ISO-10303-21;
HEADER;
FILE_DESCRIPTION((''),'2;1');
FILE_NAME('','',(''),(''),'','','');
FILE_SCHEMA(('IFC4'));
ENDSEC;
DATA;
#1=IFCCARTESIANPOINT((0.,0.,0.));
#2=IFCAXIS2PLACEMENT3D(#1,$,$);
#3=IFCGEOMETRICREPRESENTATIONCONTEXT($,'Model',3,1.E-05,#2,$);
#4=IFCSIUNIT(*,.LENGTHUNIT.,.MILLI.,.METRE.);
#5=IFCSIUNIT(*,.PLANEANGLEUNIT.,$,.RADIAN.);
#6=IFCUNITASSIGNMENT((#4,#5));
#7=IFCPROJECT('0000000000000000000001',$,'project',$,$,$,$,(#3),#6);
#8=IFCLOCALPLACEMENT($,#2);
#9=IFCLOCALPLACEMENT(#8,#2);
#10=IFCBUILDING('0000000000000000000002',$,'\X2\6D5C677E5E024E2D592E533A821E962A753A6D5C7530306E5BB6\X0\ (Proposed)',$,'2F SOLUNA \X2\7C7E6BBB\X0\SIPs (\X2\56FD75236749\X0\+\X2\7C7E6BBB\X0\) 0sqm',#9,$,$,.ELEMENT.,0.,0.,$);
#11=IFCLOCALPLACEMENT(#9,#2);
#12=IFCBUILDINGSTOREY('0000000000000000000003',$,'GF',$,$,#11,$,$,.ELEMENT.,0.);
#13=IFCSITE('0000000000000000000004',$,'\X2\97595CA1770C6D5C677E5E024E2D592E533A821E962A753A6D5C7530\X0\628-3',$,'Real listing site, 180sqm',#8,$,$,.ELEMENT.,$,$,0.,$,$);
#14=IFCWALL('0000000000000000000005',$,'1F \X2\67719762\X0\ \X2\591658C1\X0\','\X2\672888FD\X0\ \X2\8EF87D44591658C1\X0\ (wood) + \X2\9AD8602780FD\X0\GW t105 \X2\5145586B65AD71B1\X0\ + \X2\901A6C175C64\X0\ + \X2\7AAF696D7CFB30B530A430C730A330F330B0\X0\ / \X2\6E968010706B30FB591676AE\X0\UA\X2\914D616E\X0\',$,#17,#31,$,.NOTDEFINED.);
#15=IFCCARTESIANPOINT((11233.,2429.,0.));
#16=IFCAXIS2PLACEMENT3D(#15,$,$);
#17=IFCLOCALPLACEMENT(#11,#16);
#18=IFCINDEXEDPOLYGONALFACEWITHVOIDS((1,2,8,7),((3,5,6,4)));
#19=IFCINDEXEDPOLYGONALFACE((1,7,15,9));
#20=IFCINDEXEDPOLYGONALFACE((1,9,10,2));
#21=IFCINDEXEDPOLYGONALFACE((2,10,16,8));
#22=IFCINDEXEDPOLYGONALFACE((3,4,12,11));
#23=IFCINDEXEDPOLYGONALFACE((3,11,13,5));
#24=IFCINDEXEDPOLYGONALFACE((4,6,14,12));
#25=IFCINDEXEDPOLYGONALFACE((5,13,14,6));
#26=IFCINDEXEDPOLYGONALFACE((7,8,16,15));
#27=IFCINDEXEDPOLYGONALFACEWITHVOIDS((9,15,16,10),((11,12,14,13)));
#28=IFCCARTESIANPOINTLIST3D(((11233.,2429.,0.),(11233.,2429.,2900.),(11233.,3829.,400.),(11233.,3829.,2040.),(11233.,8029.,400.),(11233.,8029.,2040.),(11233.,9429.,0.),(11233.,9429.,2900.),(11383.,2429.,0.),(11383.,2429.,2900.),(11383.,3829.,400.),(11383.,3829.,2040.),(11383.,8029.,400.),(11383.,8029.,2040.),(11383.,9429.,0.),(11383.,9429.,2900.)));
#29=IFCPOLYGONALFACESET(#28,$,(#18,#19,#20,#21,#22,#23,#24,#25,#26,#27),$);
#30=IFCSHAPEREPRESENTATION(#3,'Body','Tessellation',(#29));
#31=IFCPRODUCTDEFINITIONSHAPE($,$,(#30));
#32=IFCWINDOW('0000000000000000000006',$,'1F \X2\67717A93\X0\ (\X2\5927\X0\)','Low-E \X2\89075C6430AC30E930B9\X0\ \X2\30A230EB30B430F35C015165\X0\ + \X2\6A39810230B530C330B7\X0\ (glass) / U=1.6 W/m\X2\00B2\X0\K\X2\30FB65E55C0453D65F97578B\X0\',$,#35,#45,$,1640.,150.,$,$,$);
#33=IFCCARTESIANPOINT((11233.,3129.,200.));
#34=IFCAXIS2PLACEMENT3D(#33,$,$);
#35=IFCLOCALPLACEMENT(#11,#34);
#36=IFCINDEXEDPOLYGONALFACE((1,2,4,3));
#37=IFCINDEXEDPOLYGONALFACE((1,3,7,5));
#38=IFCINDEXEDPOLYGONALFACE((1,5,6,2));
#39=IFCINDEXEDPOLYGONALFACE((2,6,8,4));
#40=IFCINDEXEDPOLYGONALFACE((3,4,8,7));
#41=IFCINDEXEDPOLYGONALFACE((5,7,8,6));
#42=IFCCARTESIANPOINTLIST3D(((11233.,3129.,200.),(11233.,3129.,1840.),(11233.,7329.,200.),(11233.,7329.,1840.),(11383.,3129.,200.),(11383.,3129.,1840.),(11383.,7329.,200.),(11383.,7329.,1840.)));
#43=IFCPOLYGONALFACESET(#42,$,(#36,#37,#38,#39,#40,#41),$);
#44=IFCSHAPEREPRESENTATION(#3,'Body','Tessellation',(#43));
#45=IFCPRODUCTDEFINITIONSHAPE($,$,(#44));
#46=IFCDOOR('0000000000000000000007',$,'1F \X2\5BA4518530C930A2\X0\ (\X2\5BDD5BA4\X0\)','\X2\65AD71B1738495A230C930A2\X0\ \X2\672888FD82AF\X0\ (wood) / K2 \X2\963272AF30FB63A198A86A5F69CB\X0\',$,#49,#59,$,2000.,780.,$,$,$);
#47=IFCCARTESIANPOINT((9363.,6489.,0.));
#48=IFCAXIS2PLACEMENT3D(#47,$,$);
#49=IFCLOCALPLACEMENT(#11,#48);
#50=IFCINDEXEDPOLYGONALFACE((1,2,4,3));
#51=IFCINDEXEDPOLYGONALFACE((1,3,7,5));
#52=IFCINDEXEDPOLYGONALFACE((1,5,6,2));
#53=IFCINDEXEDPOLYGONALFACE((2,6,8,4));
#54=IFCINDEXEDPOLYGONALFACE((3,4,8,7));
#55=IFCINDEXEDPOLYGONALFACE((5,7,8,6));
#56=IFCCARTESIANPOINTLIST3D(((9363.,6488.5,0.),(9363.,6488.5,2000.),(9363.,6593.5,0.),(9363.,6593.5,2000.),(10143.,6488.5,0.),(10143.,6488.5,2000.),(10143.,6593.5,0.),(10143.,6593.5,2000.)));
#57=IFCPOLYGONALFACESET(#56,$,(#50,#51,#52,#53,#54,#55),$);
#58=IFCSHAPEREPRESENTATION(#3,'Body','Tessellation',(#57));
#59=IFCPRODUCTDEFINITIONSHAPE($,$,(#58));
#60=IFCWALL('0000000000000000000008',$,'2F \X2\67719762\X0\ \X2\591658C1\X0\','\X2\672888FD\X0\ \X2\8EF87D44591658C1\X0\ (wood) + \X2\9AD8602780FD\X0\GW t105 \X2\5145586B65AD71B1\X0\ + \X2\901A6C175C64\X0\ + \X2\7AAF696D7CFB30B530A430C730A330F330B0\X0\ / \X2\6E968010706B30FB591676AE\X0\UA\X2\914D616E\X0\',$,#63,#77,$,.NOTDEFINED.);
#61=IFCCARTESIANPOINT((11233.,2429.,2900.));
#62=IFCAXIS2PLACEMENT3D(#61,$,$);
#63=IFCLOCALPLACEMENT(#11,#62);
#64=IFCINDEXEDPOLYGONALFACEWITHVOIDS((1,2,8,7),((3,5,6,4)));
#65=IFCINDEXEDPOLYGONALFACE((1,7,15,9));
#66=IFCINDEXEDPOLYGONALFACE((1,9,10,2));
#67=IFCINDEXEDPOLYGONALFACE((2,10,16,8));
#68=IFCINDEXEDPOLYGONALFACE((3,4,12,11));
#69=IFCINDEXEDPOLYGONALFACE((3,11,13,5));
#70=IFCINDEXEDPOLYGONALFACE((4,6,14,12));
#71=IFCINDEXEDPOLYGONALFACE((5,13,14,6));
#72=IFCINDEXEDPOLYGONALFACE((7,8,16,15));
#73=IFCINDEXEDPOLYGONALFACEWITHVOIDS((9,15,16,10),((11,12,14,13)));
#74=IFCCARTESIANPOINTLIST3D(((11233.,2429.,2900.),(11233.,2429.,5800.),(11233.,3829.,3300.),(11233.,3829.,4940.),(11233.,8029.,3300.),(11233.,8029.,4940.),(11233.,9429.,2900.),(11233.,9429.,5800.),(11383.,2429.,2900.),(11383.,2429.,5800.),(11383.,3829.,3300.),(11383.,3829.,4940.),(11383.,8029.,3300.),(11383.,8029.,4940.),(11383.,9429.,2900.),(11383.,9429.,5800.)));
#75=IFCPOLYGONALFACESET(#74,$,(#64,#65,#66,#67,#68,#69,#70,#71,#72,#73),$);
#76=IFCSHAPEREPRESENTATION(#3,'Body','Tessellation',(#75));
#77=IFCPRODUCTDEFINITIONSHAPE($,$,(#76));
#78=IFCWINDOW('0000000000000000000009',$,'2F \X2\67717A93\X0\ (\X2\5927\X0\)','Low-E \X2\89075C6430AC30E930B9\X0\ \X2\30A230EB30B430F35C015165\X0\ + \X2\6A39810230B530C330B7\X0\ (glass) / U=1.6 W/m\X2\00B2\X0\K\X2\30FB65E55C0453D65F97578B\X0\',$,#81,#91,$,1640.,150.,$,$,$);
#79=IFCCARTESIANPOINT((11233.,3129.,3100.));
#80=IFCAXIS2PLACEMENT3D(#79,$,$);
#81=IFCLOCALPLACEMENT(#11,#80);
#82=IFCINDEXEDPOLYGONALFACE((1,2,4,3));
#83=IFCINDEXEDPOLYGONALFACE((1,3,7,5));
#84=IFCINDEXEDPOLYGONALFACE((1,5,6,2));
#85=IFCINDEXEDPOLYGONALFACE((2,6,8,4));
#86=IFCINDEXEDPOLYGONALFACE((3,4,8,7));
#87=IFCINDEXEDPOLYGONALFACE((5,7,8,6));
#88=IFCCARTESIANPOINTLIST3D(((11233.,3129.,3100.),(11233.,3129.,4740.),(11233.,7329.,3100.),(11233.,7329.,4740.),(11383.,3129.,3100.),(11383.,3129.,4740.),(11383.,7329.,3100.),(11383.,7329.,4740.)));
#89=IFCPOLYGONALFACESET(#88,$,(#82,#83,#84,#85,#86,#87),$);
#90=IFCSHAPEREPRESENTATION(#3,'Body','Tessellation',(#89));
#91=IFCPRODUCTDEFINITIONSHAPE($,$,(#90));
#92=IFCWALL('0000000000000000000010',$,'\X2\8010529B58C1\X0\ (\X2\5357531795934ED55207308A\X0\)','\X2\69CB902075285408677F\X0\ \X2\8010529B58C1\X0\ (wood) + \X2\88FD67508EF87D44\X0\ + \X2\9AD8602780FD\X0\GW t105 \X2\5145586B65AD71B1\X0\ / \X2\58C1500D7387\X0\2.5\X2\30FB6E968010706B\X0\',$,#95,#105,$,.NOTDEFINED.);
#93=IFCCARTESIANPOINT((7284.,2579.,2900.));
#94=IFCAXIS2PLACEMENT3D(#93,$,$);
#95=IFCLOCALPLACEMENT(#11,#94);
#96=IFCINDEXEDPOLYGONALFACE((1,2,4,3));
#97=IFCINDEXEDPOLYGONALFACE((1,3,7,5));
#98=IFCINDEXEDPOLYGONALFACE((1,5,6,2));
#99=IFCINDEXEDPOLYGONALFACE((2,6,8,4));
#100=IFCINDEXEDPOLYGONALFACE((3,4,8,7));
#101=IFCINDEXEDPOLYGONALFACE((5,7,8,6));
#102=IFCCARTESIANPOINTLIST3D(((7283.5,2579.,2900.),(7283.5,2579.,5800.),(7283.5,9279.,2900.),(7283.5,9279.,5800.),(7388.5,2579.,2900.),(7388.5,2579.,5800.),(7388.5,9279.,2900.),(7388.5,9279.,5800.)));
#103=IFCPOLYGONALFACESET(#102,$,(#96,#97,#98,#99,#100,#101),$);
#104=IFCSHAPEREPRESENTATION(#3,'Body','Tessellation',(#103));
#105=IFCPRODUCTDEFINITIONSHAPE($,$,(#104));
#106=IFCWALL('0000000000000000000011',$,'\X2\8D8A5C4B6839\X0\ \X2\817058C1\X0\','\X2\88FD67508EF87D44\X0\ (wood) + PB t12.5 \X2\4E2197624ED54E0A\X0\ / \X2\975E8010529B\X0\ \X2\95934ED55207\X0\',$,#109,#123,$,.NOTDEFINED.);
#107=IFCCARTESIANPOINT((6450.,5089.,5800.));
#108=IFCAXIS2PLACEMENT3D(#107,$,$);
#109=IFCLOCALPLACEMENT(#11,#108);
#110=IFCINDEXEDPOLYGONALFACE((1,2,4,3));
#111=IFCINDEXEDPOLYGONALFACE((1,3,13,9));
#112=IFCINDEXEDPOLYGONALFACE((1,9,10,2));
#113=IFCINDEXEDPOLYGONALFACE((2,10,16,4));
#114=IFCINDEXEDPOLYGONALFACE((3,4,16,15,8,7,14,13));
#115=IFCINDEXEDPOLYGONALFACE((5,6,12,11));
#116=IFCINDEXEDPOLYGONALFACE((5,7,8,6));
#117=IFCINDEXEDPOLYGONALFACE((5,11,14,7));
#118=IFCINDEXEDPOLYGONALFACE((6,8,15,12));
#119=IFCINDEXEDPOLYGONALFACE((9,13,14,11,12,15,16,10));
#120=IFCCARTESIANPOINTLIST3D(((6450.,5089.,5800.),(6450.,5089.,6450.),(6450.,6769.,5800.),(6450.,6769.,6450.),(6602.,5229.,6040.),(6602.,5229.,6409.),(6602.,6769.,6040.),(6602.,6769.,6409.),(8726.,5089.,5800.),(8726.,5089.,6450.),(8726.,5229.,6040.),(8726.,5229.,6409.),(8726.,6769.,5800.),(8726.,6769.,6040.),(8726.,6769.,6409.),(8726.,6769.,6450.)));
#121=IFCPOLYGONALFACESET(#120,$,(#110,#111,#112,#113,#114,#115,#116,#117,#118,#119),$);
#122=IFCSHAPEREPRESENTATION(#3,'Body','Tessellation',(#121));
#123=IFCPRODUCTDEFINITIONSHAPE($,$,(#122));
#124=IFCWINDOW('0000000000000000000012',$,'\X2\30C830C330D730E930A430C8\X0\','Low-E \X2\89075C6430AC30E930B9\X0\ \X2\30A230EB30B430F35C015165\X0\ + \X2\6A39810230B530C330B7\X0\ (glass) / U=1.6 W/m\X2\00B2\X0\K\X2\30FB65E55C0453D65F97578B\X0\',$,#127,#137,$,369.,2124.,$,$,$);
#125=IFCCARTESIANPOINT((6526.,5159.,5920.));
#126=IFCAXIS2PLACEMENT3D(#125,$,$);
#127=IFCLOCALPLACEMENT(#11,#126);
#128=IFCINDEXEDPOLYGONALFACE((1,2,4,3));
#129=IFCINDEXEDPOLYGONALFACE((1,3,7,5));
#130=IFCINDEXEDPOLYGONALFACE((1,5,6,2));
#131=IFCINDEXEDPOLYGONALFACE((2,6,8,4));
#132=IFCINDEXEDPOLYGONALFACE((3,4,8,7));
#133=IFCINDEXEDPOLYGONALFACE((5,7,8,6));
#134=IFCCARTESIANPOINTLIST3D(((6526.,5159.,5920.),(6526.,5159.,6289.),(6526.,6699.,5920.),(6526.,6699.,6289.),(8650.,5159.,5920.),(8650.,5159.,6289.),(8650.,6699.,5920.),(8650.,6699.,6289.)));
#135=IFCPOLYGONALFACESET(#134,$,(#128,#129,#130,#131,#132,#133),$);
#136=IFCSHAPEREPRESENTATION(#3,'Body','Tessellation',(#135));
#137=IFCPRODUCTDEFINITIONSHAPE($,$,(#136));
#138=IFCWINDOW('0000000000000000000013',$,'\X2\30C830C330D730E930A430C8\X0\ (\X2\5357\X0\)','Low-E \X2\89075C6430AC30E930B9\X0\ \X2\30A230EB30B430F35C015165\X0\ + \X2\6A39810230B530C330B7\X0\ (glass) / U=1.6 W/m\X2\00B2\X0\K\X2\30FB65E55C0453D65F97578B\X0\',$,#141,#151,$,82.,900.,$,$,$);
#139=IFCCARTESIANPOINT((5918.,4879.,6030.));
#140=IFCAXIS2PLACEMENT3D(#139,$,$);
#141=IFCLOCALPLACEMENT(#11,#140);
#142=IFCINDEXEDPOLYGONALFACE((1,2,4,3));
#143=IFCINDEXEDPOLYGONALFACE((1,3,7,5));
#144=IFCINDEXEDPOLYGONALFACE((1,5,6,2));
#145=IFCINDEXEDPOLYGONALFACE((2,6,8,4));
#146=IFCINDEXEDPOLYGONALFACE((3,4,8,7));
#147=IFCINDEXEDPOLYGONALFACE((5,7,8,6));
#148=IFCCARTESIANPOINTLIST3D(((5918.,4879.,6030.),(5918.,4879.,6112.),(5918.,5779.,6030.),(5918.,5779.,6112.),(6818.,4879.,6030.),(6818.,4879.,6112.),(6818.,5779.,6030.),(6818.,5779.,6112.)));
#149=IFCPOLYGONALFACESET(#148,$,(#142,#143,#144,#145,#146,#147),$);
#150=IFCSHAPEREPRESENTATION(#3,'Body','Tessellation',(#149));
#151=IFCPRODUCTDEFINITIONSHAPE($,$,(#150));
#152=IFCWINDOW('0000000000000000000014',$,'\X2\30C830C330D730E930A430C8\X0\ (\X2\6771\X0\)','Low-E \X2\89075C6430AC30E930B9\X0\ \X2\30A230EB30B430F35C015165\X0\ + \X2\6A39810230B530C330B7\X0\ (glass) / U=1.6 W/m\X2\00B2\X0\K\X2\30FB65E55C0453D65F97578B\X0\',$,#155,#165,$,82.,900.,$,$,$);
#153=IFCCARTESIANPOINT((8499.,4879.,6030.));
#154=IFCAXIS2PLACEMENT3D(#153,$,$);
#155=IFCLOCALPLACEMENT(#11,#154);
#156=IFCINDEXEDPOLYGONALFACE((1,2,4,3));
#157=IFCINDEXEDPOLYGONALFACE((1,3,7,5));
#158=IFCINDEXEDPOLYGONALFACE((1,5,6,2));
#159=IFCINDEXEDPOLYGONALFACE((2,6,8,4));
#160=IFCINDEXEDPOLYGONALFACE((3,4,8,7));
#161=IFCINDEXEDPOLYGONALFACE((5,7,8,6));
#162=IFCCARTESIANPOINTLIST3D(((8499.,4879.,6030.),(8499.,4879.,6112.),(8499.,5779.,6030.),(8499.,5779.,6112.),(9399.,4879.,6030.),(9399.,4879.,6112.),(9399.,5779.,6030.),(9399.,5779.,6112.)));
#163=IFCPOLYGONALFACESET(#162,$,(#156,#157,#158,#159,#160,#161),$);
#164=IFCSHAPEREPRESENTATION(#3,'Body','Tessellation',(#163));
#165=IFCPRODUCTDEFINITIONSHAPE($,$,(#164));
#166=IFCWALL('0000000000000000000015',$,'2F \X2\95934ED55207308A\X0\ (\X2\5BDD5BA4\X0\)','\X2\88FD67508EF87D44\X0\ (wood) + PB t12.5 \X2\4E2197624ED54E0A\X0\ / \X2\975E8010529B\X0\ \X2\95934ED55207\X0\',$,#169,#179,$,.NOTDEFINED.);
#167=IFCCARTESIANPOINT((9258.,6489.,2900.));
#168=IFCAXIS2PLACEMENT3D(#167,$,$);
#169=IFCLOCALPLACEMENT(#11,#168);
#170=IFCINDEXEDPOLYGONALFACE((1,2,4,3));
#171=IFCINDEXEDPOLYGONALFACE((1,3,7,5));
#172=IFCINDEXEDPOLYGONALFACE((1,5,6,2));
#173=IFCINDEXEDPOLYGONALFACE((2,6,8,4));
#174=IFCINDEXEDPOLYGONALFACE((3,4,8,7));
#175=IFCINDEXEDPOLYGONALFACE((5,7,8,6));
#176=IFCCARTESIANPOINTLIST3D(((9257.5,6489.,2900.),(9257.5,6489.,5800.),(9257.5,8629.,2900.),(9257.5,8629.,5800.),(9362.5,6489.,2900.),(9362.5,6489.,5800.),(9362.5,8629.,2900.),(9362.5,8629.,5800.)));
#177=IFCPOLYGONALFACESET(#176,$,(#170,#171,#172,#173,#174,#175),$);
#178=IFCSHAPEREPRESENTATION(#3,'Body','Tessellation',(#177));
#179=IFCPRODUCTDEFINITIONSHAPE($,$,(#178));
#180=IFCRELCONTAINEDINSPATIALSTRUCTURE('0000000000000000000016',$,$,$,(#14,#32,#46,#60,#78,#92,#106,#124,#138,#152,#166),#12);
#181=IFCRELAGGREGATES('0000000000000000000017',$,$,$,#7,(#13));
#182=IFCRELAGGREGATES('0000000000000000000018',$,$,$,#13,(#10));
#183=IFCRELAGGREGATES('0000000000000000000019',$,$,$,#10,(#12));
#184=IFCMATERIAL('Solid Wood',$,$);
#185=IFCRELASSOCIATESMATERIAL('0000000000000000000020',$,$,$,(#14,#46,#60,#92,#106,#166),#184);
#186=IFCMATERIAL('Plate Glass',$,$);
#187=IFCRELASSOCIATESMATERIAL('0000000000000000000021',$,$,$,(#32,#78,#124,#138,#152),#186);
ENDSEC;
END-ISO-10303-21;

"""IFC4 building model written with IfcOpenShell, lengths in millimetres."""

from ifc_helpers import new_model, si_unit, frame, frame_2d, origin, place, context, project, spatial, rectangle, extrude, material, element, fill, save


model = new_model("IFC4")

# Units and contexts
model_context = context("Model", 3, precision=1e-05, world=origin())
ifc_project = project(units=[si_unit("LENGTHUNIT", "METRE", prefix="MILLI"), si_unit("PLANEANGLEUNIT", "RADIAN")], contexts=[model_context])

# Site, building, storey
site_placement = place(None, origin())
site = spatial("IfcSite", under=ifc_project, at=site_placement, Name="静岡県浜松市中央区舞阪町浜田628-3", ObjectType="Real listing site, 180sqm", CompositionType="ELEMENT", RefElevation=0.0)
building_placement = place(site_placement, origin())
building = spatial("IfcBuilding", under=site, at=building_placement, Name="浜松市中央区舞阪町浜田の家 (Proposed)", ObjectType="2F SOLUNA 籾殻SIPs (国産杉+籾殻) 0sqm", CompositionType="ELEMENT", ElevationOfRefHeight=0.0, ElevationOfTerrain=0.0)
storey_placement = place(building_placement, origin())
storey = spatial("IfcBuildingStorey", under=building, at=storey_placement, Name="GF", CompositionType="ELEMENT", Elevation=0.0)

# Wall, opening, window
ifc_material_1 = material(Name="Solid Wood")
wall_1_placement = place(storey_placement, frame((11233.0, 2429.0, 0.0)))
wall_1 = element("IfcWall", 1, at=wall_1_placement, inside=storey, material=ifc_material_1, Name="1F 東面 外壁", Description="木製 軸組外壁 (wood) + 高性能GW t105 充填断熱 + 通気層 + 窯業系サイディング / 準耐火・外皮UA配慮", PredefinedType="NOTDEFINED", context=model_context, shape_type="SweptSolid", body=[
    extrude(rectangle(XDim=150.0, YDim=7000.0, at=frame_2d((75.0, 3500.0))), frame((11233.0, 2429.0, 0.0)), (0.0, 0.0, 1.0), 2900.0),
])
opening_1_placement = place(storey_placement, frame((11233.0, 3129.0, 200.0)))
opening_1 = element("IfcOpeningElement", 2, at=opening_1_placement, cuts=wall_1, PredefinedType="NOTDEFINED", context=model_context, shape_type="SweptSolid", body=[
    extrude(rectangle(XDim=150.0, YDim=4200.0, at=frame_2d((75.0, 2100.0))), frame((11233.0, 3129.0, 200.0)), (0.0, 0.0, 1.0), 1640.0),
])
ifc_material_2 = material(Name="Plate Glass")
window_1_placement = place(storey_placement, frame((11233.0, 3129.0, 200.0)))
window_1 = element("IfcWindow", 3, at=window_1_placement, inside=storey, material=ifc_material_2, Name="1F 東窓 (大)", Description="Low-E 複層ガラス アルゴン封入 + 樹脂サッシ (glass) / U=1.6 W/m²K・日射取得型", OverallHeight=1640.0, OverallWidth=150.0, context=model_context, shape_type="SweptSolid", body=[
    extrude(rectangle(XDim=150.0, YDim=4200.0, at=frame_2d((75.0, 2100.0))), frame((11233.0, 3129.0, 200.0)), (0.0, 0.0, 1.0), 1640.0),
])
fill(opening_1, window_1)

# Door
door_1_placement = place(storey_placement, frame((9363.0, 6489.0, 0.0)))
element("IfcDoor", 4, at=door_1_placement, inside=storey, material=ifc_material_1, Name="1F 室内ドア (寝室)", Description="断熱玄関ドア 木製芯 (wood) / K2 防犯・採風機構", OverallHeight=2000.0, OverallWidth=780.0, context=model_context, shape_type="SweptSolid", body=[
    extrude(rectangle(XDim=780.0, YDim=105.0, at=frame_2d((390.0, 52.0))), frame((9363.0, 6489.0, 0.0)), (0.0, 0.0, 1.0), 2000.0),
])

# Wall, opening, window
wall_2_placement = place(storey_placement, frame((11233.0, 2429.0, 2900.0)))
wall_2 = element("IfcWall", 5, at=wall_2_placement, inside=storey, material=ifc_material_1, Name="2F 東面 外壁", Description="木製 軸組外壁 (wood) + 高性能GW t105 充填断熱 + 通気層 + 窯業系サイディング / 準耐火・外皮UA配慮", PredefinedType="NOTDEFINED", context=model_context, shape_type="SweptSolid", body=[
    extrude(rectangle(XDim=150.0, YDim=7000.0, at=frame_2d((75.0, 3500.0))), frame((11233.0, 2429.0, 2900.0)), (0.0, 0.0, 1.0), 2900.0),
])
opening_2_placement = place(storey_placement, frame((11233.0, 3129.0, 3100.0)))
opening_2 = element("IfcOpeningElement", 6, at=opening_2_placement, cuts=wall_2, PredefinedType="NOTDEFINED", context=model_context, shape_type="SweptSolid", body=[
    extrude(rectangle(XDim=150.0, YDim=4200.0, at=frame_2d((75.0, 2100.0))), frame((11233.0, 3129.0, 3100.0)), (0.0, 0.0, 1.0), 1640.0),
])
window_2_placement = place(storey_placement, frame((11233.0, 3129.0, 3100.0)))
window_2 = element("IfcWindow", 7, at=window_2_placement, inside=storey, material=ifc_material_2, Name="2F 東窓 (大)", Description="Low-E 複層ガラス アルゴン封入 + 樹脂サッシ (glass) / U=1.6 W/m²K・日射取得型", OverallHeight=1640.0, OverallWidth=150.0, context=model_context, shape_type="SweptSolid", body=[
    extrude(rectangle(XDim=150.0, YDim=4200.0, at=frame_2d((75.0, 2100.0))), frame((11233.0, 3129.0, 3100.0)), (0.0, 0.0, 1.0), 1640.0),
])
fill(opening_2, window_2)

# Wall
wall_3_placement = place(storey_placement, frame((7284.0, 2579.0, 2900.0)))
element("IfcWall", 8, at=wall_3_placement, inside=storey, material=ifc_material_1, Name="耐力壁 (南北間仕切り)", Description="構造用合板 耐力壁 (wood) + 製材軸組 + 高性能GW t105 充填断熱 / 壁倍率2.5・準耐火", PredefinedType="NOTDEFINED", context=model_context, shape_type="SweptSolid", body=[
    extrude(rectangle(XDim=105.0, YDim=6700.0, at=frame_2d((52.0, 3350.0))), frame((7284.0, 2579.0, 2900.0)), (0.0, 0.0, 1.0), 2900.0),
])

# Wall, openings, windows
wall_4_placement = place(storey_placement, frame((6450.0, 5089.0, 5800.0)))
wall_4 = element("IfcWall", 9, at=wall_4_placement, inside=storey, material=ifc_material_1, Name="越屋根 腰壁", Description="製材軸組 (wood) + PB t12.5 両面仕上 / 非耐力 間仕切", PredefinedType="NOTDEFINED", context=model_context, shape_type="SweptSolid", body=[
    extrude(rectangle(XDim=2276.0, YDim=1680.0, at=frame_2d((1138.0, 840.0))), frame((6450.0, 5089.0, 5800.0)), (0.0, 0.0, 1.0), 650.0),
])
opening_3_placement = place(storey_placement, frame((6526.0, 5159.0, 5920.0)))
opening_3 = element("IfcOpeningElement", 10, at=opening_3_placement, cuts=wall_4, PredefinedType="NOTDEFINED", context=model_context, shape_type="SweptSolid", body=[
    extrude(rectangle(XDim=2124.0, YDim=1540.0, at=frame_2d((1062.0, 770.0))), frame((6526.0, 5159.0, 5920.0)), (0.0, 0.0, 1.0), 369.0),
])
opening_4_placement = place(storey_placement, frame((5918.0, 4879.0, 6030.0)))
opening_4 = element("IfcOpeningElement", 11, at=opening_4_placement, cuts=wall_4, PredefinedType="NOTDEFINED", context=model_context, shape_type="SweptSolid", body=[
    extrude(rectangle(XDim=900.0, YDim=900.0, at=frame_2d((450.0, 450.0))), frame((5918.0, 4879.0, 6030.0)), (0.0, 0.0, 1.0), 82.0),
])
opening_5_placement = place(storey_placement, frame((8499.0, 4879.0, 6030.0)))
opening_5 = element("IfcOpeningElement", 12, at=opening_5_placement, cuts=wall_4, PredefinedType="NOTDEFINED", context=model_context, shape_type="SweptSolid", body=[
    extrude(rectangle(XDim=900.0, YDim=900.0, at=frame_2d((450.0, 450.0))), frame((8499.0, 4879.0, 6030.0)), (0.0, 0.0, 1.0), 82.0),
])
window_3_placement = place(storey_placement, frame((6526.0, 5159.0, 5920.0)))
window_3 = element("IfcWindow", 13, at=window_3_placement, inside=storey, material=ifc_material_2, Name="トップライト", Description="Low-E 複層ガラス アルゴン封入 + 樹脂サッシ (glass) / U=1.6 W/m²K・日射取得型", OverallHeight=369.0, OverallWidth=2124.0, context=model_context, shape_type="SweptSolid", body=[
    extrude(rectangle(XDim=2124.0, YDim=1540.0, at=frame_2d((1062.0, 770.0))), frame((6526.0, 5159.0, 5920.0)), (0.0, 0.0, 1.0), 369.0),
])
fill(opening_3, window_3)
window_4_placement = place(storey_placement, frame((5918.0, 4879.0, 6030.0)))
window_4 = element("IfcWindow", 14, at=window_4_placement, inside=storey, material=ifc_material_2, Name="トップライト (南)", Description="Low-E 複層ガラス アルゴン封入 + 樹脂サッシ (glass) / U=1.6 W/m²K・日射取得型", OverallHeight=82.0, OverallWidth=900.0, context=model_context, shape_type="SweptSolid", body=[
    extrude(rectangle(XDim=900.0, YDim=900.0, at=frame_2d((450.0, 450.0))), frame((5918.0, 4879.0, 6030.0)), (0.0, 0.0, 1.0), 82.0),
])
fill(opening_4, window_4)
window_5_placement = place(storey_placement, frame((8499.0, 4879.0, 6030.0)))
window_5 = element("IfcWindow", 15, at=window_5_placement, inside=storey, material=ifc_material_2, Name="トップライト (東)", Description="Low-E 複層ガラス アルゴン封入 + 樹脂サッシ (glass) / U=1.6 W/m²K・日射取得型", OverallHeight=82.0, OverallWidth=900.0, context=model_context, shape_type="SweptSolid", body=[
    extrude(rectangle(XDim=900.0, YDim=900.0, at=frame_2d((450.0, 450.0))), frame((8499.0, 4879.0, 6030.0)), (0.0, 0.0, 1.0), 82.0),
])
fill(opening_5, window_5)

# Wall
wall_5_placement = place(storey_placement, frame((9258.0, 6489.0, 2900.0)))
element("IfcWall", 16, at=wall_5_placement, inside=storey, material=ifc_material_1, Name="2F 間仕切り (寝室)", Description="製材軸組 (wood) + PB t12.5 両面仕上 / 非耐力 間仕切", PredefinedType="NOTDEFINED", context=model_context, shape_type="SweptSolid", body=[
    extrude(rectangle(XDim=105.0, YDim=2140.0, at=frame_2d((52.0, 1070.0))), frame((9258.0, 6489.0, 2900.0)), (0.0, 0.0, 1.0), 2900.0),
])

save(model, "model.ifc")
